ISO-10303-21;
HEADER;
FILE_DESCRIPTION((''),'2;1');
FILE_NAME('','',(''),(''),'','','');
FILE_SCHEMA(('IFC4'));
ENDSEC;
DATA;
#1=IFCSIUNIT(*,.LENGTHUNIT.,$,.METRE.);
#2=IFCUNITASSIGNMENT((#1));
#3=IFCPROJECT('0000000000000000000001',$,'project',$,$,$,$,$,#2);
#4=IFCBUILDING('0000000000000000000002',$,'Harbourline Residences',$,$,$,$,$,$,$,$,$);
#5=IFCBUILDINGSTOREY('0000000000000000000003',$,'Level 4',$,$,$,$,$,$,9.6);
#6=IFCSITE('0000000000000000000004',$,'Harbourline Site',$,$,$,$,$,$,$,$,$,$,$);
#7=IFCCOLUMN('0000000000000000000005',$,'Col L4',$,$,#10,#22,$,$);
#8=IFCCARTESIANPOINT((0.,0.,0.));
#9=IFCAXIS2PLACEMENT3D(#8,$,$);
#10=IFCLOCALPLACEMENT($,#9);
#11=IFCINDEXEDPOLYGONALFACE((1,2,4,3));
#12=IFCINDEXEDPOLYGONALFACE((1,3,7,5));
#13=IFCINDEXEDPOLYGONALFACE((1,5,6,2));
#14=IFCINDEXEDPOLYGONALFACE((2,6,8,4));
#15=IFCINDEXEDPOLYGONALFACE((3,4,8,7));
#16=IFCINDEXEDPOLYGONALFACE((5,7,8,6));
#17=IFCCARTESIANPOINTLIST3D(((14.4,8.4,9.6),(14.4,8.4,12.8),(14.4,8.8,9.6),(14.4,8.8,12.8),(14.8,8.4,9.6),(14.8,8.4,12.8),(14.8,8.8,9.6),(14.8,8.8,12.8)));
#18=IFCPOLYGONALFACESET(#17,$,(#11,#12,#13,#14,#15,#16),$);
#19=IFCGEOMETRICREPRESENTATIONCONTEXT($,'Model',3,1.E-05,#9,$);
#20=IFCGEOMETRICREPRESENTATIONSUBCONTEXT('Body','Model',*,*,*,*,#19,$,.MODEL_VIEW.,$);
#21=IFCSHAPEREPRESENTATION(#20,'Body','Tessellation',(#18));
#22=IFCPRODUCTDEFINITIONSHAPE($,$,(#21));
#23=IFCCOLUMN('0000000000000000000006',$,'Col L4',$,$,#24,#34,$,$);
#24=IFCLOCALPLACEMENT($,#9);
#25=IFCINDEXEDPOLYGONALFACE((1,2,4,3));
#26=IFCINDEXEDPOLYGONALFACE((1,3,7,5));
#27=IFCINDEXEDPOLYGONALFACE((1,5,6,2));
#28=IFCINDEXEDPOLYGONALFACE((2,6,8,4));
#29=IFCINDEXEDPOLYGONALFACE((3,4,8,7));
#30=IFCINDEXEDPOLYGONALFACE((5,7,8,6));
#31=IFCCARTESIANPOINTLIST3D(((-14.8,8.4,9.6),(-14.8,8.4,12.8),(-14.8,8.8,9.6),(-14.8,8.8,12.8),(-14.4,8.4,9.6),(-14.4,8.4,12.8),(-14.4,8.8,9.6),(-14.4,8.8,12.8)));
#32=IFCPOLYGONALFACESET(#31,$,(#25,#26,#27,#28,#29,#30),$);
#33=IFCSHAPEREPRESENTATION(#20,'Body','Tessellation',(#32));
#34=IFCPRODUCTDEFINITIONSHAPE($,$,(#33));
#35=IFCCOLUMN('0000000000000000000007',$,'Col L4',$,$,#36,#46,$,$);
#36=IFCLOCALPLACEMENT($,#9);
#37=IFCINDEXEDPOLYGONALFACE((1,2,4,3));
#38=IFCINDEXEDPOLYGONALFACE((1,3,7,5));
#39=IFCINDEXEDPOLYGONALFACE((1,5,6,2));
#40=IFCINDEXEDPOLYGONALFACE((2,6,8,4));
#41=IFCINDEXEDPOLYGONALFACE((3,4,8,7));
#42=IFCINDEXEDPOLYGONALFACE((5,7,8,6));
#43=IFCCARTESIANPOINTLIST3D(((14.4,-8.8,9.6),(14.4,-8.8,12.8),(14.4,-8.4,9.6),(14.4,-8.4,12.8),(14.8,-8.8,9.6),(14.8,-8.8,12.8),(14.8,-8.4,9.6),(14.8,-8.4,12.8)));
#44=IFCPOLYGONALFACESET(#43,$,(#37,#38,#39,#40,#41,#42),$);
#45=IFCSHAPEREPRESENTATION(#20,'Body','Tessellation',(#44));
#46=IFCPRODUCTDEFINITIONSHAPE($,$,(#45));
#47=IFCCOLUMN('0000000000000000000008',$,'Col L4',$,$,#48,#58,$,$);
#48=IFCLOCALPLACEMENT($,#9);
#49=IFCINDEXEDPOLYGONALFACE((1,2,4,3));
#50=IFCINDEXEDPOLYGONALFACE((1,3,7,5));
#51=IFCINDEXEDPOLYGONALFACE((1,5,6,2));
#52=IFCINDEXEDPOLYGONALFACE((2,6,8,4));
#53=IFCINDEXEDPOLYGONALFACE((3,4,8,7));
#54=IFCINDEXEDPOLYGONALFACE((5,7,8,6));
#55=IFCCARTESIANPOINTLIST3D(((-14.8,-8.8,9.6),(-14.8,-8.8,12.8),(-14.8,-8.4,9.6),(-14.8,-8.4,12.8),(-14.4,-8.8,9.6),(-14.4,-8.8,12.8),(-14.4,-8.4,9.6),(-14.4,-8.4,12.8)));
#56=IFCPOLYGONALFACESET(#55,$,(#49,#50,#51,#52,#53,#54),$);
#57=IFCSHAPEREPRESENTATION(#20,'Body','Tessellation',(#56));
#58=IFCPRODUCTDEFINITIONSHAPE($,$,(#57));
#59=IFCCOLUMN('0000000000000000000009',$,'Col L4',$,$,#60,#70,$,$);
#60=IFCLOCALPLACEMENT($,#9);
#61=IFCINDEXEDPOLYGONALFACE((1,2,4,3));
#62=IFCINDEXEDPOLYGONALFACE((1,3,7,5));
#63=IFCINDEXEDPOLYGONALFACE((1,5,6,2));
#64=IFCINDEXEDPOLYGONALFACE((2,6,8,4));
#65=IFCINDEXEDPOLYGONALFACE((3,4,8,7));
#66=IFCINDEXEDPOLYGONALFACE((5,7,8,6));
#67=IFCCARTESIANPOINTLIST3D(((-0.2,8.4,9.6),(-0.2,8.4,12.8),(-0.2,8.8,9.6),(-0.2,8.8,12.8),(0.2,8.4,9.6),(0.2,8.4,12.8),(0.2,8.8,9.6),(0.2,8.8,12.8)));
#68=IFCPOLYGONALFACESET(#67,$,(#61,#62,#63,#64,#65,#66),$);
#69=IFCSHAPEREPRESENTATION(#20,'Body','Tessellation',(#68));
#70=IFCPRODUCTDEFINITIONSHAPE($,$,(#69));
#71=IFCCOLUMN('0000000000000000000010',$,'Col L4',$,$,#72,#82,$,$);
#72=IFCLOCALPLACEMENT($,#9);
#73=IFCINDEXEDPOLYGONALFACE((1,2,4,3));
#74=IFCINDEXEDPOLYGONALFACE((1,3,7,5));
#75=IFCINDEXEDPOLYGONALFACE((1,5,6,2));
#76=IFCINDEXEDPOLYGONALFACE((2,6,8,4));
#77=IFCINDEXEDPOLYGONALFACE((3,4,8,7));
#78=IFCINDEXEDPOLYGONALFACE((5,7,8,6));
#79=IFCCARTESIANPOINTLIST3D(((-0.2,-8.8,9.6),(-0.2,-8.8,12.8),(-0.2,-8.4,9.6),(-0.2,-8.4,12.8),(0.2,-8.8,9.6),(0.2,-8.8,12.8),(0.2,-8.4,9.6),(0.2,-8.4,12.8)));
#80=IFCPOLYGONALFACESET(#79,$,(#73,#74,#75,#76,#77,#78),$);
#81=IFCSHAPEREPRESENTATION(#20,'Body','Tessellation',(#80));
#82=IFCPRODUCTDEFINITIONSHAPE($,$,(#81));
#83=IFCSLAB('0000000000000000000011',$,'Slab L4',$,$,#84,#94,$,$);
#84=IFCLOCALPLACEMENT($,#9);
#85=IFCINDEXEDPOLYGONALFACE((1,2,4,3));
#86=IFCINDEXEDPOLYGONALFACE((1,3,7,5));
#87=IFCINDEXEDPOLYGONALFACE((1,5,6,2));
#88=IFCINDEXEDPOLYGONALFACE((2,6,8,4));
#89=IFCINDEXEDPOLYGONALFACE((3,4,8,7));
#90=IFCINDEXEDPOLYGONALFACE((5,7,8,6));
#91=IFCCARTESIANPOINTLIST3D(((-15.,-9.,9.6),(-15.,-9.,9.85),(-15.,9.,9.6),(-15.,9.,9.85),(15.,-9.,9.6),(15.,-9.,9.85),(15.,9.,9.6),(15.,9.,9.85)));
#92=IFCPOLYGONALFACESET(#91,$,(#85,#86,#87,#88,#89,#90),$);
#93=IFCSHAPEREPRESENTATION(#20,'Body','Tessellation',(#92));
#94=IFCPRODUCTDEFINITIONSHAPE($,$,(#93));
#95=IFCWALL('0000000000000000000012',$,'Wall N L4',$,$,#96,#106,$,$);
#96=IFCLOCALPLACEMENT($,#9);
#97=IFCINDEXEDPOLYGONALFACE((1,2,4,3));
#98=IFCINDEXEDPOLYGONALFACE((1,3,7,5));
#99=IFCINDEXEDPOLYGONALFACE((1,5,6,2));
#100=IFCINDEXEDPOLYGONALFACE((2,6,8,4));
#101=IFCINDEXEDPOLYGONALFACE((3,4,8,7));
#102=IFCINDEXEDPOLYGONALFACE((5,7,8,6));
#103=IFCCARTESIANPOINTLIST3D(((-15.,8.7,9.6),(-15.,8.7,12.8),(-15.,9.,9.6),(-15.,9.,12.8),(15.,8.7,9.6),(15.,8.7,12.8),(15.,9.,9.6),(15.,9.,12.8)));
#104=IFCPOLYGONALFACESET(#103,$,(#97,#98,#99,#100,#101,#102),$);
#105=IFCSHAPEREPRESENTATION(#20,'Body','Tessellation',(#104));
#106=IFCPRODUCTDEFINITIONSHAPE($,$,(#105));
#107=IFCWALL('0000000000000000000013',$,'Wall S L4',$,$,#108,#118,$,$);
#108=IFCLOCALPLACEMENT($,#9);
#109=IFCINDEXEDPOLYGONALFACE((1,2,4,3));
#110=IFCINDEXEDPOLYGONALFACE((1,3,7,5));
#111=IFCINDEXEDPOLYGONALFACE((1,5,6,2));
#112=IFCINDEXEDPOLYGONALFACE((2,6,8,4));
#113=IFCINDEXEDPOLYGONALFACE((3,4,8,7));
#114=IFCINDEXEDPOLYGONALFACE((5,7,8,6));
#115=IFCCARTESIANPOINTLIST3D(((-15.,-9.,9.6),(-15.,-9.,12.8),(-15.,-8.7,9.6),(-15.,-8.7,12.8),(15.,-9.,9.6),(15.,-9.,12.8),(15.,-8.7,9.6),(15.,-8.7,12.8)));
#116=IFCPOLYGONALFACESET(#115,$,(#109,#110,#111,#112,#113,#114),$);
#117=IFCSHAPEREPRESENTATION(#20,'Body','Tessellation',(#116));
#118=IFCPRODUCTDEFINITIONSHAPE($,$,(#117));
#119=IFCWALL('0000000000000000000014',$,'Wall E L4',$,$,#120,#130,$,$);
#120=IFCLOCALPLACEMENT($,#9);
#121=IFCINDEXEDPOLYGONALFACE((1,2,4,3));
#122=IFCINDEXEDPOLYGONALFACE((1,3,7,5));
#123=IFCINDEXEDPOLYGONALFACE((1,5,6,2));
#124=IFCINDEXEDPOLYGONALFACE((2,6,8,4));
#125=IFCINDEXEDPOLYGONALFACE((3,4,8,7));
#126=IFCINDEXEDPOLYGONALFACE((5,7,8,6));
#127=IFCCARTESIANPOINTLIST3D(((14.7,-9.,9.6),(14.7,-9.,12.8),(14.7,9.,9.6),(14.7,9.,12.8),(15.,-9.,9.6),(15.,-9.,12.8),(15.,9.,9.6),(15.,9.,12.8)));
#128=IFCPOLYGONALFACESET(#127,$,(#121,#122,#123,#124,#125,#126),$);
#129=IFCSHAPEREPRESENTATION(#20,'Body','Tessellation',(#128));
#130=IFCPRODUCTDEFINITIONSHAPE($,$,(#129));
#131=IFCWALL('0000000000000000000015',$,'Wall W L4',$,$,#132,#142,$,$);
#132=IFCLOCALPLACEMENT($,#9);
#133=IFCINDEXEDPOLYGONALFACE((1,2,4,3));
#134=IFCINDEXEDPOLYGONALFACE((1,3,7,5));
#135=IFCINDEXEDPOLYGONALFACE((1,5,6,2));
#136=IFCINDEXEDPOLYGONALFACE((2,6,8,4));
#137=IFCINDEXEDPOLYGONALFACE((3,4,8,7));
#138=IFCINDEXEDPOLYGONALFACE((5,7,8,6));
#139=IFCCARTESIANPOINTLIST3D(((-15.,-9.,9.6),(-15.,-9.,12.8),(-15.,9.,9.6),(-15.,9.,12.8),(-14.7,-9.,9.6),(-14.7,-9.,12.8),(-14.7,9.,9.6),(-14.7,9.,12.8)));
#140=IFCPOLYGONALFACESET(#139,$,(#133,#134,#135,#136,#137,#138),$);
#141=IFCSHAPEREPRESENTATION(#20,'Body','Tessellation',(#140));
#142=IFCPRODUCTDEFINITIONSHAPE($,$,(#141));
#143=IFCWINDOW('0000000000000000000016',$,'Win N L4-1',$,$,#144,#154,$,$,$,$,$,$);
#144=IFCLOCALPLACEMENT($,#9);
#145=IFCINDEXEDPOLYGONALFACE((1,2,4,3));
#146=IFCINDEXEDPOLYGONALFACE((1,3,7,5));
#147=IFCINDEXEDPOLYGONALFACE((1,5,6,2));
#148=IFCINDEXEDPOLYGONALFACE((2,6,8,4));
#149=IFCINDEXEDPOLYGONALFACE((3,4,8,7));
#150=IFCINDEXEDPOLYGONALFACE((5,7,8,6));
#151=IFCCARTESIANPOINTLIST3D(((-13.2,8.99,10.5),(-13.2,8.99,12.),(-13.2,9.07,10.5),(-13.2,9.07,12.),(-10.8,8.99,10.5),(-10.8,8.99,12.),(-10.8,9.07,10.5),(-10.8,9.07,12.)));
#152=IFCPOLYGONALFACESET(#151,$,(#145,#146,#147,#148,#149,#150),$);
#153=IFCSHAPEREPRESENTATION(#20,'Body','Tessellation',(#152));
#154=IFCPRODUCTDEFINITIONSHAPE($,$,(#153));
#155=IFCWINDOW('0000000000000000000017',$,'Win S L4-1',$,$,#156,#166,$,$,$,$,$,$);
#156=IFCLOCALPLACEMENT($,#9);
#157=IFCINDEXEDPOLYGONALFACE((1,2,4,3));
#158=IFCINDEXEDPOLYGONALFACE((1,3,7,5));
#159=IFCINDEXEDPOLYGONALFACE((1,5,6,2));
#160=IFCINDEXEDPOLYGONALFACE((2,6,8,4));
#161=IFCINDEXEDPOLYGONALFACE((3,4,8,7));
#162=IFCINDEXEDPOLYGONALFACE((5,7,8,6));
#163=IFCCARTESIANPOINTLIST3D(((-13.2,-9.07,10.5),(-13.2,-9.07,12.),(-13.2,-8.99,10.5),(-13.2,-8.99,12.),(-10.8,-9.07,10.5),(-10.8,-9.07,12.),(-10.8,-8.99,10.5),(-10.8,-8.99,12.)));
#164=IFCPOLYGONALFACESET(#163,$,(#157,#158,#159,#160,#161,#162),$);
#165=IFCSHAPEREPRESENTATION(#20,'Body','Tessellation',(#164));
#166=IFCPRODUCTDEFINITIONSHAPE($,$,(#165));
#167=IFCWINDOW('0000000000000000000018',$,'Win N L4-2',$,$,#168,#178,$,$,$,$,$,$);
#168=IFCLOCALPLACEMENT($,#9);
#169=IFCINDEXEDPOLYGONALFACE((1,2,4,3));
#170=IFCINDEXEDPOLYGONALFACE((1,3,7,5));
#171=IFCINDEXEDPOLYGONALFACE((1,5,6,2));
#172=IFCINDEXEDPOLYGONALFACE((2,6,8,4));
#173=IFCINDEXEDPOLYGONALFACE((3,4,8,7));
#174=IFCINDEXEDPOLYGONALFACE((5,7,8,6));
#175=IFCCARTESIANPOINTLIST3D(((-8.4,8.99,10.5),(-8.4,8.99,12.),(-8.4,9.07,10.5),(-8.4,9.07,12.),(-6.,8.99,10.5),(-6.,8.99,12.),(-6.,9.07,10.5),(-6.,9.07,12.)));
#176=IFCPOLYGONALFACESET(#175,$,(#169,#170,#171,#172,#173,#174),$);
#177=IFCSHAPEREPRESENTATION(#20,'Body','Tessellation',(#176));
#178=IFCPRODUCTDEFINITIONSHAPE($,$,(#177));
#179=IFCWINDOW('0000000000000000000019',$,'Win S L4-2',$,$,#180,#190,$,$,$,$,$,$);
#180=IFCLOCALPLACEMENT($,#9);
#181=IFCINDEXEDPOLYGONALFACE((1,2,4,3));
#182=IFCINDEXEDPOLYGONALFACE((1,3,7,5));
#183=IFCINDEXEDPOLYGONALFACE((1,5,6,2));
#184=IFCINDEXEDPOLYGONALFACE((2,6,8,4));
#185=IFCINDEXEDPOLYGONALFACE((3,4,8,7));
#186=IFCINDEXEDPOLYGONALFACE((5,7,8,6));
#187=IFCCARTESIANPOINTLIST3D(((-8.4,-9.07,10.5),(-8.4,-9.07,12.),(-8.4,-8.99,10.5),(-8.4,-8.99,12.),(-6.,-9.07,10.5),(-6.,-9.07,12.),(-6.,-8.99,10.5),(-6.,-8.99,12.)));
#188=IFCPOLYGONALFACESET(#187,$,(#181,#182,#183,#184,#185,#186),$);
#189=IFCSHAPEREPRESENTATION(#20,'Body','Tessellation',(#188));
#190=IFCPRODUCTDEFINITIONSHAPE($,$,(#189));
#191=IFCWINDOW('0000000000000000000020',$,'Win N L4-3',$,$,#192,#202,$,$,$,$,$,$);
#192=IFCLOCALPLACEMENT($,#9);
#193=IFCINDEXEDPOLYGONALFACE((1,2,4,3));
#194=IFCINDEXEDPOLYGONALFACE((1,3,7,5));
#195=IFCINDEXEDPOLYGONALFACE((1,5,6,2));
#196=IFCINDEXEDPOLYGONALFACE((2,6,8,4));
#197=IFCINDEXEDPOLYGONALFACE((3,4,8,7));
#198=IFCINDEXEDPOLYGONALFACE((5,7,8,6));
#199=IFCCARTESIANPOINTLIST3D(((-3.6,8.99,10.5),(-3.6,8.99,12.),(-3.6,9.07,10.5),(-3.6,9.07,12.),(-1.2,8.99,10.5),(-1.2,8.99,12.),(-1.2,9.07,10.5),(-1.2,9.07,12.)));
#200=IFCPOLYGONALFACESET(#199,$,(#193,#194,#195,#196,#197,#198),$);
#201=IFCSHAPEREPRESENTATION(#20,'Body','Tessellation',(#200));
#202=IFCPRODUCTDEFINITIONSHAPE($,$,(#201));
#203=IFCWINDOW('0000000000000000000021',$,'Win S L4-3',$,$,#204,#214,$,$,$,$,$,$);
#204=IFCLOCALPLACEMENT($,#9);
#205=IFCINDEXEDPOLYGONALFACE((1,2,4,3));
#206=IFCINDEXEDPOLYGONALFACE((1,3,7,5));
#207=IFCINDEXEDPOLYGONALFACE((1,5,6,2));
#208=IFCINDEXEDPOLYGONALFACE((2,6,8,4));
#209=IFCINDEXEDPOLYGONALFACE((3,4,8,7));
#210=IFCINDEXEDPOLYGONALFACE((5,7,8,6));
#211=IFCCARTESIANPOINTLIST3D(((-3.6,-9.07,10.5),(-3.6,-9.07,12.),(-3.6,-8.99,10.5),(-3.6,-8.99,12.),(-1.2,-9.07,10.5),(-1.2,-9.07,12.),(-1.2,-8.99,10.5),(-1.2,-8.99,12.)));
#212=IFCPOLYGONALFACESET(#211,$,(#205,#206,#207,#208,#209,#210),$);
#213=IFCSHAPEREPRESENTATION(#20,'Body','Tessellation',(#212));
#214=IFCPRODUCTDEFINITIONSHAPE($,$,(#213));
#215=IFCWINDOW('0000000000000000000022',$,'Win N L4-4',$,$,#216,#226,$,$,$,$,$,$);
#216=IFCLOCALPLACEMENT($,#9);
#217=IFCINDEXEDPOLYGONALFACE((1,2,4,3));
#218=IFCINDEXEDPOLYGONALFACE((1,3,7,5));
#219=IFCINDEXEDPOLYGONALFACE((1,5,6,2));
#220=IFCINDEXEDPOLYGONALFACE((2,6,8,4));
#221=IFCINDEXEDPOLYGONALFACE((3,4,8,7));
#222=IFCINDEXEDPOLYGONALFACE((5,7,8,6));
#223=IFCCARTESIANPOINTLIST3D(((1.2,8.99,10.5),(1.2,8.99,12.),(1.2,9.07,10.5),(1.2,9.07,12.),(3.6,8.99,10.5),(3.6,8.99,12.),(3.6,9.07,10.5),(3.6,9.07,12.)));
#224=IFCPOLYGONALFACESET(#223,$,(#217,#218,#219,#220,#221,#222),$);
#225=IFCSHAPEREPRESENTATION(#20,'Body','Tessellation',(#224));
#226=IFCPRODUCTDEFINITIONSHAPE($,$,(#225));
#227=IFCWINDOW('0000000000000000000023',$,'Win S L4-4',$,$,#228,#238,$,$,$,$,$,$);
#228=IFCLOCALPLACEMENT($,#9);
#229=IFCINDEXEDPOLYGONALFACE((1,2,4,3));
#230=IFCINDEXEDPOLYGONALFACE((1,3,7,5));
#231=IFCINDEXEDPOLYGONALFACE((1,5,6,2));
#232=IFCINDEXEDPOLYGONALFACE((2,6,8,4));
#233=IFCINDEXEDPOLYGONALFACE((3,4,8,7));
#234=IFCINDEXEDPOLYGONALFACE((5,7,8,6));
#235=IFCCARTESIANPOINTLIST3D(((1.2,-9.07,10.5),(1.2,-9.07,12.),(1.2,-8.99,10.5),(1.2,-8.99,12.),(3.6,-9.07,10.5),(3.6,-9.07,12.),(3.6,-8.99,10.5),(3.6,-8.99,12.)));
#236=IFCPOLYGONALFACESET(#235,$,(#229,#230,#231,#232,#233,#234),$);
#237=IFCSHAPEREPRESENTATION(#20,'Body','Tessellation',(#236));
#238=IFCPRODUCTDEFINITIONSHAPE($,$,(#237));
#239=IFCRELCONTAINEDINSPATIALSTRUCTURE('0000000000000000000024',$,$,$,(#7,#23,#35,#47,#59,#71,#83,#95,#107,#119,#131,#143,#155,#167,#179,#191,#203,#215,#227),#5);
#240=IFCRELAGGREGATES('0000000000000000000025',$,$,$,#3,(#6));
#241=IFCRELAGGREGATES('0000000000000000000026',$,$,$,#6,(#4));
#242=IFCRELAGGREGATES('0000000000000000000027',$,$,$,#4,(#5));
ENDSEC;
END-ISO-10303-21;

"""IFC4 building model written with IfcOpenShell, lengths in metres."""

from ifc_helpers import new_model, si_unit, frame, frame_2d, origin, origin_2d, context, subcontext, project, spatial, rectangle, extrude, element, save


model = new_model("IFC4")

# Units and contexts
model_context = context("Model", 3, precision=1e-05, world=origin())
body_context = subcontext(model_context, "Body", "Model", "MODEL_VIEW")
ifc_project = project(units=[si_unit("LENGTHUNIT", "METRE")])

# Site, building, storey
site = spatial("IfcSite", under=ifc_project, Name="Harbourline Site")
building = spatial("IfcBuilding", under=site, Name="Harbourline Residences")
storey = spatial("IfcBuildingStorey", under=building, Name="Level 4", Elevation=9.6)

# Columns
element("IfcColumn", 1, inside=storey, Name="Col L4", context=body_context, shape_type="SweptSolid", body=[
    extrude(rectangle(XDim=0.4, YDim=0.4, at=frame_2d((14.6, 8.6))), frame((0.0, 0.0, 9.6)), (0.0, 0.0, 1.0), 3.2),
])
element("IfcColumn", 2, inside=storey, Name="Col L4", context=body_context, shape_type="SweptSolid", body=[
    extrude(rectangle(XDim=0.4, YDim=0.4, at=frame_2d((-14.6, 8.6))), frame((0.0, 0.0, 9.6)), (0.0, 0.0, 1.0), 3.2),
])
element("IfcColumn", 3, inside=storey, Name="Col L4", context=body_context, shape_type="SweptSolid", body=[
    extrude(rectangle(XDim=0.4, YDim=0.4, at=frame_2d((14.6, -8.6))), frame((0.0, 0.0, 9.6)), (0.0, 0.0, 1.0), 3.2),
])
element("IfcColumn", 4, inside=storey, Name="Col L4", context=body_context, shape_type="SweptSolid", body=[
    extrude(rectangle(XDim=0.4, YDim=0.4, at=frame_2d((-14.6, -8.6))), frame((0.0, 0.0, 9.6)), (0.0, 0.0, 1.0), 3.2),
])
element("IfcColumn", 5, inside=storey, Name="Col L4", context=body_context, shape_type="SweptSolid", body=[
    extrude(rectangle(XDim=0.4, YDim=0.4, at=frame_2d((0.0, 8.6))), frame((0.0, 0.0, 9.6)), (0.0, 0.0, 1.0), 3.2),
])
element("IfcColumn", 6, inside=storey, Name="Col L4", context=body_context, shape_type="SweptSolid", body=[
    extrude(rectangle(XDim=0.4, YDim=0.4, at=frame_2d((0.0, -8.6))), frame((0.0, 0.0, 9.6)), (0.0, 0.0, 1.0), 3.2),
])

# Slab
element("IfcSlab", 7, inside=storey, Name="Slab L4", context=body_context, shape_type="SweptSolid", body=[
    extrude(rectangle(XDim=30.0, YDim=18.0, at=origin_2d()), frame((0.0, 0.0, 9.6)), (0.0, 0.0, 1.0), 0.25),
])

# Walls
element("IfcWall", 8, inside=storey, Name="Wall N L4", context=body_context, shape_type="SweptSolid", body=[
    extrude(rectangle(XDim=30.0, YDim=0.3, at=frame_2d((0.0, 8.85))), frame((0.0, 0.0, 9.6)), (0.0, 0.0, 1.0), 3.2),
])
element("IfcWall", 9, inside=storey, Name="Wall S L4", context=body_context, shape_type="SweptSolid", body=[
    extrude(rectangle(XDim=30.0, YDim=0.3, at=frame_2d((0.0, -8.85))), frame((0.0, 0.0, 9.6)), (0.0, 0.0, 1.0), 3.2),
])
element("IfcWall", 10, inside=storey, Name="Wall E L4", context=body_context, shape_type="SweptSolid", body=[
    extrude(rectangle(XDim=0.3, YDim=18.0, at=frame_2d((14.85, 0.0))), frame((0.0, 0.0, 9.6)), (0.0, 0.0, 1.0), 3.2),
])
element("IfcWall", 11, inside=storey, Name="Wall W L4", context=body_context, shape_type="SweptSolid", body=[
    extrude(rectangle(XDim=0.3, YDim=18.0, at=frame_2d((-14.85, 0.0))), frame((0.0, 0.0, 9.6)), (0.0, 0.0, 1.0), 3.2),
])

# Windows
element("IfcWindow", 12, inside=storey, Name="Win N L4-1", context=body_context, shape_type="SweptSolid", body=[
    extrude(rectangle(XDim=2.4, YDim=0.08, at=frame_2d((-12.0, 9.03))), frame((0.0, 0.0, 10.5)), (0.0, 0.0, 1.0), 1.5),
])
element("IfcWindow", 13, inside=storey, Name="Win S L4-1", context=body_context, shape_type="SweptSolid", body=[
    extrude(rectangle(XDim=2.4, YDim=0.08, at=frame_2d((-12.0, -9.03))), frame((0.0, 0.0, 10.5)), (0.0, 0.0, 1.0), 1.5),
])
element("IfcWindow", 14, inside=storey, Name="Win N L4-2", context=body_context, shape_type="SweptSolid", body=[
    extrude(rectangle(XDim=2.4, YDim=0.08, at=frame_2d((-7.2, 9.03))), frame((0.0, 0.0, 10.5)), (0.0, 0.0, 1.0), 1.5),
])
element("IfcWindow", 15, inside=storey, Name="Win S L4-2", context=body_context, shape_type="SweptSolid", body=[
    extrude(rectangle(XDim=2.4, YDim=0.08, at=frame_2d((-7.2, -9.03))), frame((0.0, 0.0, 10.5)), (0.0, 0.0, 1.0), 1.5),
])
element("IfcWindow", 16, inside=storey, Name="Win N L4-3", context=body_context, shape_type="SweptSolid", body=[
    extrude(rectangle(XDim=2.4, YDim=0.08, at=frame_2d((-2.4, 9.03))), frame((0.0, 0.0, 10.5)), (0.0, 0.0, 1.0), 1.5),
])
element("IfcWindow", 17, inside=storey, Name="Win S L4-3", context=body_context, shape_type="SweptSolid", body=[
    extrude(rectangle(XDim=2.4, YDim=0.08, at=frame_2d((-2.4, -9.03))), frame((0.0, 0.0, 10.5)), (0.0, 0.0, 1.0), 1.5),
])
element("IfcWindow", 18, inside=storey, Name="Win N L4-4", context=body_context, shape_type="SweptSolid", body=[
    extrude(rectangle(XDim=2.4, YDim=0.08, at=frame_2d((2.4, 9.03))), frame((0.0, 0.0, 10.5)), (0.0, 0.0, 1.0), 1.5),
])
element("IfcWindow", 19, inside=storey, Name="Win S L4-4", context=body_context, shape_type="SweptSolid", body=[
    extrude(rectangle(XDim=2.4, YDim=0.08, at=frame_2d((2.4, -9.03))), frame((0.0, 0.0, 10.5)), (0.0, 0.0, 1.0), 1.5),
])

save(model, "model.ifc")
